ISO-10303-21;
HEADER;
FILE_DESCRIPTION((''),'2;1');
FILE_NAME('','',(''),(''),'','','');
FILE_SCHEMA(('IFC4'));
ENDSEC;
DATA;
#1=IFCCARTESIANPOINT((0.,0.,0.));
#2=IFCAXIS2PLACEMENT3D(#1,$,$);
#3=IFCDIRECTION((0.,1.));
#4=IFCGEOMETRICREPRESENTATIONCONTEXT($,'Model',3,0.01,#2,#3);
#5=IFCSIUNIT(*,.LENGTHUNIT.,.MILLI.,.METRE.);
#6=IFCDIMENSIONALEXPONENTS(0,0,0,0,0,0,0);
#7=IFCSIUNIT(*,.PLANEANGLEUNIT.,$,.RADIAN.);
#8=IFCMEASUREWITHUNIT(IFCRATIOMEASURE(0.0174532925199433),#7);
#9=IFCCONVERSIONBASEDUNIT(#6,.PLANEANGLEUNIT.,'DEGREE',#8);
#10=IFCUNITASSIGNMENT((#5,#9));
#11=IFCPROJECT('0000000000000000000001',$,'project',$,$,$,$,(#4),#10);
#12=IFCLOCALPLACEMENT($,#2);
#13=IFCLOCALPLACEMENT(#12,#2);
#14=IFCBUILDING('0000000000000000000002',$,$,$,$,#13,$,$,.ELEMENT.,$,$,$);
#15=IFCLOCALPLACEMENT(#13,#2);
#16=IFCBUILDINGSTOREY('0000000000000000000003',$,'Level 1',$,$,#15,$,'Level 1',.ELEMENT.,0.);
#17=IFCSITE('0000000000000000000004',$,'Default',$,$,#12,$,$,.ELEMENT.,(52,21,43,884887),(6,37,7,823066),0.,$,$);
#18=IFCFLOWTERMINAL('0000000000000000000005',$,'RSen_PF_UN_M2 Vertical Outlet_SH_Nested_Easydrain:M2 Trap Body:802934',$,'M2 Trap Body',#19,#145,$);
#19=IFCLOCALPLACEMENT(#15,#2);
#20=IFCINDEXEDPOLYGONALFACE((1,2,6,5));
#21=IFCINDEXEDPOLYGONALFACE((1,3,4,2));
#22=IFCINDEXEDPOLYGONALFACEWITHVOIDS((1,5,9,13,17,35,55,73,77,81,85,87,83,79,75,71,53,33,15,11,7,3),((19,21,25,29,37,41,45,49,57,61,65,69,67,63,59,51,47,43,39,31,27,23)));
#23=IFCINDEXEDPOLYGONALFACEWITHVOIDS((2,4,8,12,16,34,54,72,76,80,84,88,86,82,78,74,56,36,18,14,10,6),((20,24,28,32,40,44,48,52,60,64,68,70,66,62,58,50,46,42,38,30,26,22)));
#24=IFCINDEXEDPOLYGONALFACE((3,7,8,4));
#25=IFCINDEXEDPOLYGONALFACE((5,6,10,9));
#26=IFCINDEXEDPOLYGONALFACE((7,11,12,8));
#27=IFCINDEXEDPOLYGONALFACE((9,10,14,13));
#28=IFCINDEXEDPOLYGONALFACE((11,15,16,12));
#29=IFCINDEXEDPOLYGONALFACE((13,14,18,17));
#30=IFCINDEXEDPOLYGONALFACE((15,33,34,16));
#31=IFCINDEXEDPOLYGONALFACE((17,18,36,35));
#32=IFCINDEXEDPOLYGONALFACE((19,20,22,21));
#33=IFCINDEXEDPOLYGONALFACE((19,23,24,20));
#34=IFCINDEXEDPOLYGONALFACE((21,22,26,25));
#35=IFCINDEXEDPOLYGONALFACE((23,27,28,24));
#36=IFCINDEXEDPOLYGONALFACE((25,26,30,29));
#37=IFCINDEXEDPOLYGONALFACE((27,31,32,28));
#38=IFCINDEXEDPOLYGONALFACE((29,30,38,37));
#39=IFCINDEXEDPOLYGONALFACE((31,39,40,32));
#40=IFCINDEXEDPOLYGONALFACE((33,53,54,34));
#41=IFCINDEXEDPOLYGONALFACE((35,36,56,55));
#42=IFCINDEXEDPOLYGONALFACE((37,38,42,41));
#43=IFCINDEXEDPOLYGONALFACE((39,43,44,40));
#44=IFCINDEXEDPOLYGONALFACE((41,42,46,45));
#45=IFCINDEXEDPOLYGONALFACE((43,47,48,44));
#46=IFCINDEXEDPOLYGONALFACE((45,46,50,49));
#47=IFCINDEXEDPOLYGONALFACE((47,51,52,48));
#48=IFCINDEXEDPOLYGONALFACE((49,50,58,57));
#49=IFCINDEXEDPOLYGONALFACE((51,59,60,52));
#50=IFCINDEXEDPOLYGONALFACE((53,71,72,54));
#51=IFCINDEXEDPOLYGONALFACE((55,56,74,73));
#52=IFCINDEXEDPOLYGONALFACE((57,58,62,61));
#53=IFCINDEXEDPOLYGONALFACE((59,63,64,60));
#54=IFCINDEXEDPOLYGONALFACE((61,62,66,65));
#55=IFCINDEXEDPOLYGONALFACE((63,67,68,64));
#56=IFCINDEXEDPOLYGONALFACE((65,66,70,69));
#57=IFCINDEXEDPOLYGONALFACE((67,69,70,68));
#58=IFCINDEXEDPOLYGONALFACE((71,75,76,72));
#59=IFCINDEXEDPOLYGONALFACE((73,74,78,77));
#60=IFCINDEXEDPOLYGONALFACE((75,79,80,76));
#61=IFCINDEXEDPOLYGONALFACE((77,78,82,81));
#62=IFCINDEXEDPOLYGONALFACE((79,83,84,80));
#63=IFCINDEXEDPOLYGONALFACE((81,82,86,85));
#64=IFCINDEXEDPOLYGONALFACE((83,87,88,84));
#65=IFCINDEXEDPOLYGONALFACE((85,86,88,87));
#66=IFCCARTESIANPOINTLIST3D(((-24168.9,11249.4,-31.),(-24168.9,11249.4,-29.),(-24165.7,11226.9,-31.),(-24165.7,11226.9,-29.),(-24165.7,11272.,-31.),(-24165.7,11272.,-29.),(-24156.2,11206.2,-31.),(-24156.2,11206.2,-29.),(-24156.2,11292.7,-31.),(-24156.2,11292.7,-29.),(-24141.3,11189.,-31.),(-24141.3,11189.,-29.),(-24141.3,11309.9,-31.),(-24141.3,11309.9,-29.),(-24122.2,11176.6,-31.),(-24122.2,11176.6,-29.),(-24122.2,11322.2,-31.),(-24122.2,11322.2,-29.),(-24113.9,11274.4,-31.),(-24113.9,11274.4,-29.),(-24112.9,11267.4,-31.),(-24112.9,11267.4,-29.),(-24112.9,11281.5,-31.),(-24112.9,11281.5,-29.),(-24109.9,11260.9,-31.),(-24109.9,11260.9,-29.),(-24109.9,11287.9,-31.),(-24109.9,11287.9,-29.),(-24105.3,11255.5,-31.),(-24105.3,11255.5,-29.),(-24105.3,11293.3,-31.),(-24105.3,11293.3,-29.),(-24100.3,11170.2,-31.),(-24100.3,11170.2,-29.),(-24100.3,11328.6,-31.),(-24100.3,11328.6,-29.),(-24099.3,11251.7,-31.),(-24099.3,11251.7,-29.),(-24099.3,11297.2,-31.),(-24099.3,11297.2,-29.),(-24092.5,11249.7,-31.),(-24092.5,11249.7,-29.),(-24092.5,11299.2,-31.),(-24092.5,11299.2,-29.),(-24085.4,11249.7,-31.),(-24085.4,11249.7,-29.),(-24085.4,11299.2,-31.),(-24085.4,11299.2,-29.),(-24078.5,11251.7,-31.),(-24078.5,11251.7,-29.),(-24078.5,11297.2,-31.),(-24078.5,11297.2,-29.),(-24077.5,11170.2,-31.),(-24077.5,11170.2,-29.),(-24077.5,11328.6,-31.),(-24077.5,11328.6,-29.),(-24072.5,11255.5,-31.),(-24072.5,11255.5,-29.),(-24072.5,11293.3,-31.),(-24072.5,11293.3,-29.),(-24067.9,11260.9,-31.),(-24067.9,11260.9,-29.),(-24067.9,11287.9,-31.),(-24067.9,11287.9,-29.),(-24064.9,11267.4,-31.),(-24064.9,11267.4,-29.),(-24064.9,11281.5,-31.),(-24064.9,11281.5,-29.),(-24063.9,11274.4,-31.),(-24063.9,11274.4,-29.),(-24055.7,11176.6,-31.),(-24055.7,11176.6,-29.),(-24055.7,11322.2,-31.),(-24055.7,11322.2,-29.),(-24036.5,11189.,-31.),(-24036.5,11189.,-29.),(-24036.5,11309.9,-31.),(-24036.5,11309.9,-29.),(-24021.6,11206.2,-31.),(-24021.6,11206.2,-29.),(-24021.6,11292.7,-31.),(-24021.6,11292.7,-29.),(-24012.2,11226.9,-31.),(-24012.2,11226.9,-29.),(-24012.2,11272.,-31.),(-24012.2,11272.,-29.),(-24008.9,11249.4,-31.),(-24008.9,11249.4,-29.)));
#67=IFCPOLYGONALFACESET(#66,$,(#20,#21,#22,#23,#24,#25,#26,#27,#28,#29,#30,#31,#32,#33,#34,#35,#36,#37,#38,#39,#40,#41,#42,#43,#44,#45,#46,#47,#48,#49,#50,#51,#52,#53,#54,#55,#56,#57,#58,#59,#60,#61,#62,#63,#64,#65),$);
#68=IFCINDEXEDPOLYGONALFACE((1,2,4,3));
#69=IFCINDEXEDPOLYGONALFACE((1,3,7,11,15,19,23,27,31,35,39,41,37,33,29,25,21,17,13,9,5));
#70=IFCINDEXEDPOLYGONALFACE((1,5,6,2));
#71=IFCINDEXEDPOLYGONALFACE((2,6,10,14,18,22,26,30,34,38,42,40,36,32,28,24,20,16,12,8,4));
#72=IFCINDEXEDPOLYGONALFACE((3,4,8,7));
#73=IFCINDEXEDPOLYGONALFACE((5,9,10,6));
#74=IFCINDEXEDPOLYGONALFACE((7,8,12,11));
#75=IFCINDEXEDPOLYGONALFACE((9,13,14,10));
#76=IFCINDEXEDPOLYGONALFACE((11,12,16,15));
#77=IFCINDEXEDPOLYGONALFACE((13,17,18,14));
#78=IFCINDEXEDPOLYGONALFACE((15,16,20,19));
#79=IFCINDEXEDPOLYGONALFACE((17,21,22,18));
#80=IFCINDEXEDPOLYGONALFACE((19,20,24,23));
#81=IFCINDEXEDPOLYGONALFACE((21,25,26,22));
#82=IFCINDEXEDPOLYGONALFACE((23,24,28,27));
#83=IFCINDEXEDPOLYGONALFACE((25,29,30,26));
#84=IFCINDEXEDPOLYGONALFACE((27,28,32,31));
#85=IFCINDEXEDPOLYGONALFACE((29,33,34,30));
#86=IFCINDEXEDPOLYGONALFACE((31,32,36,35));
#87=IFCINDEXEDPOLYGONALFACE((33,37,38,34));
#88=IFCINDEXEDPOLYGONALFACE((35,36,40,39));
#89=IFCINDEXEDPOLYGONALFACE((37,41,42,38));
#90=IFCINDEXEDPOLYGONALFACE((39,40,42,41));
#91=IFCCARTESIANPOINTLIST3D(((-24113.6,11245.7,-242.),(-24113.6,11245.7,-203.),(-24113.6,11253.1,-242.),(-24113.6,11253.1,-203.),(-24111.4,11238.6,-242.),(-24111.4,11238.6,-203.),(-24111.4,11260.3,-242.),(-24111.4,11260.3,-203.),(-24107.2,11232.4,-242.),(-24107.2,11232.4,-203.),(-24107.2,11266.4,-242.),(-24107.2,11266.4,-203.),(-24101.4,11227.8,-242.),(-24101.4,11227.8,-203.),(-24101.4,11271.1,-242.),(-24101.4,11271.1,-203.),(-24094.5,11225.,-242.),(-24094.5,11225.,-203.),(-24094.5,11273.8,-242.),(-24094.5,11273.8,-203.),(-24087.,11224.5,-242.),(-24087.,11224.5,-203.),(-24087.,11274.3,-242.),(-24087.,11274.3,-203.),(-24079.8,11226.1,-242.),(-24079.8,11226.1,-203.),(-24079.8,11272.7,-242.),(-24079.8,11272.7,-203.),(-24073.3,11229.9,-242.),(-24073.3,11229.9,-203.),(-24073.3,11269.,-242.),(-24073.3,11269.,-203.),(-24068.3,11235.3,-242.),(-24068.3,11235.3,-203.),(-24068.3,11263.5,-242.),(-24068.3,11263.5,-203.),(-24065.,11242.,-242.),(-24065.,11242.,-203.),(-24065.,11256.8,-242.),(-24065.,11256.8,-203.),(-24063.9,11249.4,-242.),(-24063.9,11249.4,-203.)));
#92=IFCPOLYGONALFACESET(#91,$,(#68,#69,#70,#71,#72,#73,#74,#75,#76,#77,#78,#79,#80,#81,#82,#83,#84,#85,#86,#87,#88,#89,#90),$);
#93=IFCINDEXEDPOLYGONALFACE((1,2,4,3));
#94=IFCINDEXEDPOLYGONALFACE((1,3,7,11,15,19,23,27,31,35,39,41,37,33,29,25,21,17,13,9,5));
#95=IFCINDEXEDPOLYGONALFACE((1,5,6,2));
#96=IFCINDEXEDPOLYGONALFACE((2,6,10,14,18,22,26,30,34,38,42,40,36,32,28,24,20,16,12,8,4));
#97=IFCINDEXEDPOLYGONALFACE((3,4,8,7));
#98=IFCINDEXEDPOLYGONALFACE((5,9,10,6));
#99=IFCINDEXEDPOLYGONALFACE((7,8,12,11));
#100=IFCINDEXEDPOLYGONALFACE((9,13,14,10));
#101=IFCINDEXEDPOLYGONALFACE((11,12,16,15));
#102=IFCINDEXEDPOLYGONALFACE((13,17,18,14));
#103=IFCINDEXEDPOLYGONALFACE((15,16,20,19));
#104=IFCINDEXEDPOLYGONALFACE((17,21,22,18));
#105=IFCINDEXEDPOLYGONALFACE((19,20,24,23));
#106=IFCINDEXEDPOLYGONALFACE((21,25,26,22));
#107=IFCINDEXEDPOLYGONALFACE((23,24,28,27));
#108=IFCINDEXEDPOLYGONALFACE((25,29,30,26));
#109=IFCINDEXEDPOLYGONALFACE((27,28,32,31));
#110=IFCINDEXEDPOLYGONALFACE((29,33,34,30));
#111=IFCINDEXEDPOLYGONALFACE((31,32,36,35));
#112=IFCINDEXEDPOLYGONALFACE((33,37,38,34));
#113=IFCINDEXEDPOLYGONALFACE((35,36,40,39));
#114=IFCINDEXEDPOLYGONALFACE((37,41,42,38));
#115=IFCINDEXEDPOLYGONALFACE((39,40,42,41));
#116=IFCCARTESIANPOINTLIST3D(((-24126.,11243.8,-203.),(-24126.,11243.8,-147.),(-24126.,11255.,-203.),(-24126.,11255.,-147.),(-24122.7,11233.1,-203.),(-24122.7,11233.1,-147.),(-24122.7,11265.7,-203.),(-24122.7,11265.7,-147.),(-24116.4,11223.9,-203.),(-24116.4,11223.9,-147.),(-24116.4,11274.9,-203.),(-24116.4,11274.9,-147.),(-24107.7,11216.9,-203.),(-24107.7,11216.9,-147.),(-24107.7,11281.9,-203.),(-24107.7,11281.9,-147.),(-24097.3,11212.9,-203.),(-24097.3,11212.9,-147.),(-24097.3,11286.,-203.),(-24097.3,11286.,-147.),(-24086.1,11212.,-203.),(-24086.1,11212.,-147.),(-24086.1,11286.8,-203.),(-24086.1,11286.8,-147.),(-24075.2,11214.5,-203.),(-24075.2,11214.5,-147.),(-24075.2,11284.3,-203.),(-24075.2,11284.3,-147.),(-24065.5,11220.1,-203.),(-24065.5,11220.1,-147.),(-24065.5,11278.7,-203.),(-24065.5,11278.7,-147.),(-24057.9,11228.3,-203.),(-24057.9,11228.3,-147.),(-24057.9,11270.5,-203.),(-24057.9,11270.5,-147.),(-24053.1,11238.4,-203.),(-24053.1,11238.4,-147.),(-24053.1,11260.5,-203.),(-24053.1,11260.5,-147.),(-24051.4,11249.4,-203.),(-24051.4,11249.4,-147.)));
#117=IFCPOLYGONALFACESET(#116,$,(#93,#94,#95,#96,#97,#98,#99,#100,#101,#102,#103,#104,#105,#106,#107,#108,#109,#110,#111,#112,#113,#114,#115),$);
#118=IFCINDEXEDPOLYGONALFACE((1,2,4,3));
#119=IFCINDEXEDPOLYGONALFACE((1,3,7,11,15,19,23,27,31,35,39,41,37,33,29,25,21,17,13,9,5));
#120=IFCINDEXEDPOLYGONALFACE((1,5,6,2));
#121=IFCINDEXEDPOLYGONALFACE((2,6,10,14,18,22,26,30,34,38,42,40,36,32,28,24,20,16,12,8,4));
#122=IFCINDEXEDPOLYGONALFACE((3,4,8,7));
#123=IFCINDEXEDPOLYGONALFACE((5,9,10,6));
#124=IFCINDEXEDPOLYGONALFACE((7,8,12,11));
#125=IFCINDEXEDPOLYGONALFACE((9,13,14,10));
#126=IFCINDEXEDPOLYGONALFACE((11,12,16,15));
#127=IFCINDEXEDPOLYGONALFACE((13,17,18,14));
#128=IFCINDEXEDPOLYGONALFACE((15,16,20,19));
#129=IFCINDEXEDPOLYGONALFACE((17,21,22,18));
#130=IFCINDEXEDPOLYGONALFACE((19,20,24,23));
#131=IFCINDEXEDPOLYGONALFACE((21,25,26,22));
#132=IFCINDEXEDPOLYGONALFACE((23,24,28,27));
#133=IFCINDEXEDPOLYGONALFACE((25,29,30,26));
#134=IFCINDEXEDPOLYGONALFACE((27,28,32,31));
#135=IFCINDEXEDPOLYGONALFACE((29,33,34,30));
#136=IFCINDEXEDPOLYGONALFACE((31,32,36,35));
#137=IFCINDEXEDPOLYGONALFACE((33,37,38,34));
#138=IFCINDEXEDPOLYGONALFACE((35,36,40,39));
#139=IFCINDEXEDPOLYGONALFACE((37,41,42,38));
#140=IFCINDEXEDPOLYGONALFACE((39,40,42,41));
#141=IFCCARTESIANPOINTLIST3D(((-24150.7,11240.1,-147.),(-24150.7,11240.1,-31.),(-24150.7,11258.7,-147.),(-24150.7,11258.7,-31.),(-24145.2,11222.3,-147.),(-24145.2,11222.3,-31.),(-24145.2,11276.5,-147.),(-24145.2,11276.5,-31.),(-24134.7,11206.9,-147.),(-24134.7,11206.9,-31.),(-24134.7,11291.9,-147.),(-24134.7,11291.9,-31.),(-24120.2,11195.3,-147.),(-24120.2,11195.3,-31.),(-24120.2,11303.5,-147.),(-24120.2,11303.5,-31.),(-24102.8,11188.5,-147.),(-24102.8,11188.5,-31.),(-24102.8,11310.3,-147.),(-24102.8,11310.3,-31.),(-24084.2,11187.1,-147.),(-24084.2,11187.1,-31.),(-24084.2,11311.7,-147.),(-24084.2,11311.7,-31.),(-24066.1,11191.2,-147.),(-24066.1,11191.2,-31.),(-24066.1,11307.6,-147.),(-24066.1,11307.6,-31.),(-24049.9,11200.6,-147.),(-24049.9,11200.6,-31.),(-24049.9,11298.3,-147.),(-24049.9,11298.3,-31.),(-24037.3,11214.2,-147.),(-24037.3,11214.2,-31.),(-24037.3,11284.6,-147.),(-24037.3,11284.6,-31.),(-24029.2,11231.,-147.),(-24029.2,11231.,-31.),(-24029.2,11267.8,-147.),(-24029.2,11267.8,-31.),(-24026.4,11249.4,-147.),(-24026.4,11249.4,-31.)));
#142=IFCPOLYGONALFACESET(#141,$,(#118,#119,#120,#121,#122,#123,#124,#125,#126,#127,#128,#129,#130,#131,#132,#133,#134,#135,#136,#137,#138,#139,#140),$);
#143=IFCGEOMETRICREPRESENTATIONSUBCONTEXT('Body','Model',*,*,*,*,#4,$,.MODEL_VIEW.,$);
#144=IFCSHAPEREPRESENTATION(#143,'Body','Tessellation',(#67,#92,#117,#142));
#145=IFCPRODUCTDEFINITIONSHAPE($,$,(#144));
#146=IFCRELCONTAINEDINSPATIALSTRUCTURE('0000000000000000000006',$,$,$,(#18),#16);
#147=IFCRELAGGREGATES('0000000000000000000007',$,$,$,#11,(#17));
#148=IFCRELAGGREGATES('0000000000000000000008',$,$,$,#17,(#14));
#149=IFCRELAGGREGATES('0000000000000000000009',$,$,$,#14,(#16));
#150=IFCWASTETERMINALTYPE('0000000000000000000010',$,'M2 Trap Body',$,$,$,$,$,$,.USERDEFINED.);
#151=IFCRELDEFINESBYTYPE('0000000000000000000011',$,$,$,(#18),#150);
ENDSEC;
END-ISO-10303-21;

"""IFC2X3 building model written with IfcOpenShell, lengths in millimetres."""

from ifc_helpers import new_model, entity, si_unit, converted_unit, direction, frame, frame_2d, origin, origin_2d_with_axis, place, context, subcontext, project, spatial, circle_curve, parameter, trimmed, segment, composite_curve, circle, outline, extrude, source, transform, mapped, type_object, type_shapes, element, save


model = new_model("IFC2X3")

# Units and contexts
model_context = context("Model", 3, precision=0.01, world=origin(), true_north=direction((0.0, 1.0)))
body_context = subcontext(model_context, "Body", "Model", "MODEL_VIEW")
ifc_project = project(units=[si_unit("LENGTHUNIT", "METRE", prefix="MILLI"), converted_unit("PLANEANGLEUNIT", "DEGREE", entity("IfcRatioMeasure", 0.0174532925199433), si_unit("PLANEANGLEUNIT", "RADIAN"), dimensions=[0, 0, 0, 0, 0, 0, 0])], contexts=[model_context])

# Site, building, storey
site_placement = place(None, origin())
site = spatial("IfcSite", under=ifc_project, at=site_placement, Name="Default", CompositionType="ELEMENT", RefLatitude=(52, 21, 43, 884887), RefLongitude=(6, 37, 7, 823066), RefElevation=0.0)
building_placement = place(site_placement, origin())
building = spatial("IfcBuilding", under=site, at=building_placement, CompositionType="ELEMENT")
storey_placement = place(building_placement, origin())
storey = spatial("IfcBuildingStorey", under=building, at=storey_placement, Name="Level 1", LongName="Level 1", CompositionType="ELEMENT", Elevation=0.0)

# Flow terminal
waste_terminal_type_1 = type_object("IfcWasteTerminalType", Name="M2 Trap Body", PredefinedType="USERDEFINED")
shared_shape_1 = source(origin(), body_context, "Body", "SweptSolid", [
    extrude(outline(composite_curve([segment(trimmed(circle_curve(origin_2d_with_axis(), 80.0), [parameter(0.0)], [parameter(180.0)], True, "PARAMETER"), True, "CONTINUOUS"), segment(trimmed(circle_curve(origin_2d_with_axis(), 80.0), [parameter(180.0)], [parameter(360.0)], True, "PARAMETER"), True, "CONTINUOUS")], self_intersect=False), holes=[composite_curve([segment(trimmed(circle_curve(frame_2d((0.0, 25.0), x_axis=(1.0, 0.0)), 25.0), [parameter(180.0)], [parameter(360.0)], True, "PARAMETER"), False, "CONTINUOUS"), segment(trimmed(circle_curve(frame_2d((0.0, 25.0), x_axis=(1.0, 0.0)), 25.0), [parameter(0.0)], [parameter(180.0)], True, "PARAMETER"), False, "CONTINUOUS")], self_intersect=False)]), frame((0.0, -25.0, -2.0)), (0.0, 0.0, 1.0), 2.0),
    extrude(circle(Radius=25.0, at=frame_2d((0.0, 0.0), x_axis=(1.0, 0.0))), frame((0.0, -25.0, -213.0)), (0.0, 0.0, 1.0), 39.0),
    extrude(circle(Radius=37.5, at=frame_2d((0.0, 0.0), x_axis=(1.0, 0.0))), frame((0.0, -25.0, -174.0)), (0.0, 0.0, 1.0), 56.0),
    extrude(circle(Radius=62.5, at=frame_2d((0.0, 0.0), x_axis=(1.0, 0.0))), frame((0.0, -25.0, -118.0)), (0.0, 0.0, 1.0), 116.0),
])
type_shapes(waste_terminal_type_1, [shared_shape_1])
for number, where, name in (
    (1, (-24088.9, 11274.4, -29.0), "RSen_PF_UN_M2 Vertical Outlet_SH_Nested_Easydrain:M2 Trap Body:802934"),
):
    element("IfcFlowTerminal", number, at=place(storey_placement, frame(where)), inside=storey, type_object=waste_terminal_type_1, Name=name, ObjectType="M2 Trap Body", context=body_context, shape_type="MappedRepresentation", body=[
        mapped(shared_shape_1, transform((0.0, 0.0, 0.0), scale=1.0)),
    ])

save(model, "model.ifc")
